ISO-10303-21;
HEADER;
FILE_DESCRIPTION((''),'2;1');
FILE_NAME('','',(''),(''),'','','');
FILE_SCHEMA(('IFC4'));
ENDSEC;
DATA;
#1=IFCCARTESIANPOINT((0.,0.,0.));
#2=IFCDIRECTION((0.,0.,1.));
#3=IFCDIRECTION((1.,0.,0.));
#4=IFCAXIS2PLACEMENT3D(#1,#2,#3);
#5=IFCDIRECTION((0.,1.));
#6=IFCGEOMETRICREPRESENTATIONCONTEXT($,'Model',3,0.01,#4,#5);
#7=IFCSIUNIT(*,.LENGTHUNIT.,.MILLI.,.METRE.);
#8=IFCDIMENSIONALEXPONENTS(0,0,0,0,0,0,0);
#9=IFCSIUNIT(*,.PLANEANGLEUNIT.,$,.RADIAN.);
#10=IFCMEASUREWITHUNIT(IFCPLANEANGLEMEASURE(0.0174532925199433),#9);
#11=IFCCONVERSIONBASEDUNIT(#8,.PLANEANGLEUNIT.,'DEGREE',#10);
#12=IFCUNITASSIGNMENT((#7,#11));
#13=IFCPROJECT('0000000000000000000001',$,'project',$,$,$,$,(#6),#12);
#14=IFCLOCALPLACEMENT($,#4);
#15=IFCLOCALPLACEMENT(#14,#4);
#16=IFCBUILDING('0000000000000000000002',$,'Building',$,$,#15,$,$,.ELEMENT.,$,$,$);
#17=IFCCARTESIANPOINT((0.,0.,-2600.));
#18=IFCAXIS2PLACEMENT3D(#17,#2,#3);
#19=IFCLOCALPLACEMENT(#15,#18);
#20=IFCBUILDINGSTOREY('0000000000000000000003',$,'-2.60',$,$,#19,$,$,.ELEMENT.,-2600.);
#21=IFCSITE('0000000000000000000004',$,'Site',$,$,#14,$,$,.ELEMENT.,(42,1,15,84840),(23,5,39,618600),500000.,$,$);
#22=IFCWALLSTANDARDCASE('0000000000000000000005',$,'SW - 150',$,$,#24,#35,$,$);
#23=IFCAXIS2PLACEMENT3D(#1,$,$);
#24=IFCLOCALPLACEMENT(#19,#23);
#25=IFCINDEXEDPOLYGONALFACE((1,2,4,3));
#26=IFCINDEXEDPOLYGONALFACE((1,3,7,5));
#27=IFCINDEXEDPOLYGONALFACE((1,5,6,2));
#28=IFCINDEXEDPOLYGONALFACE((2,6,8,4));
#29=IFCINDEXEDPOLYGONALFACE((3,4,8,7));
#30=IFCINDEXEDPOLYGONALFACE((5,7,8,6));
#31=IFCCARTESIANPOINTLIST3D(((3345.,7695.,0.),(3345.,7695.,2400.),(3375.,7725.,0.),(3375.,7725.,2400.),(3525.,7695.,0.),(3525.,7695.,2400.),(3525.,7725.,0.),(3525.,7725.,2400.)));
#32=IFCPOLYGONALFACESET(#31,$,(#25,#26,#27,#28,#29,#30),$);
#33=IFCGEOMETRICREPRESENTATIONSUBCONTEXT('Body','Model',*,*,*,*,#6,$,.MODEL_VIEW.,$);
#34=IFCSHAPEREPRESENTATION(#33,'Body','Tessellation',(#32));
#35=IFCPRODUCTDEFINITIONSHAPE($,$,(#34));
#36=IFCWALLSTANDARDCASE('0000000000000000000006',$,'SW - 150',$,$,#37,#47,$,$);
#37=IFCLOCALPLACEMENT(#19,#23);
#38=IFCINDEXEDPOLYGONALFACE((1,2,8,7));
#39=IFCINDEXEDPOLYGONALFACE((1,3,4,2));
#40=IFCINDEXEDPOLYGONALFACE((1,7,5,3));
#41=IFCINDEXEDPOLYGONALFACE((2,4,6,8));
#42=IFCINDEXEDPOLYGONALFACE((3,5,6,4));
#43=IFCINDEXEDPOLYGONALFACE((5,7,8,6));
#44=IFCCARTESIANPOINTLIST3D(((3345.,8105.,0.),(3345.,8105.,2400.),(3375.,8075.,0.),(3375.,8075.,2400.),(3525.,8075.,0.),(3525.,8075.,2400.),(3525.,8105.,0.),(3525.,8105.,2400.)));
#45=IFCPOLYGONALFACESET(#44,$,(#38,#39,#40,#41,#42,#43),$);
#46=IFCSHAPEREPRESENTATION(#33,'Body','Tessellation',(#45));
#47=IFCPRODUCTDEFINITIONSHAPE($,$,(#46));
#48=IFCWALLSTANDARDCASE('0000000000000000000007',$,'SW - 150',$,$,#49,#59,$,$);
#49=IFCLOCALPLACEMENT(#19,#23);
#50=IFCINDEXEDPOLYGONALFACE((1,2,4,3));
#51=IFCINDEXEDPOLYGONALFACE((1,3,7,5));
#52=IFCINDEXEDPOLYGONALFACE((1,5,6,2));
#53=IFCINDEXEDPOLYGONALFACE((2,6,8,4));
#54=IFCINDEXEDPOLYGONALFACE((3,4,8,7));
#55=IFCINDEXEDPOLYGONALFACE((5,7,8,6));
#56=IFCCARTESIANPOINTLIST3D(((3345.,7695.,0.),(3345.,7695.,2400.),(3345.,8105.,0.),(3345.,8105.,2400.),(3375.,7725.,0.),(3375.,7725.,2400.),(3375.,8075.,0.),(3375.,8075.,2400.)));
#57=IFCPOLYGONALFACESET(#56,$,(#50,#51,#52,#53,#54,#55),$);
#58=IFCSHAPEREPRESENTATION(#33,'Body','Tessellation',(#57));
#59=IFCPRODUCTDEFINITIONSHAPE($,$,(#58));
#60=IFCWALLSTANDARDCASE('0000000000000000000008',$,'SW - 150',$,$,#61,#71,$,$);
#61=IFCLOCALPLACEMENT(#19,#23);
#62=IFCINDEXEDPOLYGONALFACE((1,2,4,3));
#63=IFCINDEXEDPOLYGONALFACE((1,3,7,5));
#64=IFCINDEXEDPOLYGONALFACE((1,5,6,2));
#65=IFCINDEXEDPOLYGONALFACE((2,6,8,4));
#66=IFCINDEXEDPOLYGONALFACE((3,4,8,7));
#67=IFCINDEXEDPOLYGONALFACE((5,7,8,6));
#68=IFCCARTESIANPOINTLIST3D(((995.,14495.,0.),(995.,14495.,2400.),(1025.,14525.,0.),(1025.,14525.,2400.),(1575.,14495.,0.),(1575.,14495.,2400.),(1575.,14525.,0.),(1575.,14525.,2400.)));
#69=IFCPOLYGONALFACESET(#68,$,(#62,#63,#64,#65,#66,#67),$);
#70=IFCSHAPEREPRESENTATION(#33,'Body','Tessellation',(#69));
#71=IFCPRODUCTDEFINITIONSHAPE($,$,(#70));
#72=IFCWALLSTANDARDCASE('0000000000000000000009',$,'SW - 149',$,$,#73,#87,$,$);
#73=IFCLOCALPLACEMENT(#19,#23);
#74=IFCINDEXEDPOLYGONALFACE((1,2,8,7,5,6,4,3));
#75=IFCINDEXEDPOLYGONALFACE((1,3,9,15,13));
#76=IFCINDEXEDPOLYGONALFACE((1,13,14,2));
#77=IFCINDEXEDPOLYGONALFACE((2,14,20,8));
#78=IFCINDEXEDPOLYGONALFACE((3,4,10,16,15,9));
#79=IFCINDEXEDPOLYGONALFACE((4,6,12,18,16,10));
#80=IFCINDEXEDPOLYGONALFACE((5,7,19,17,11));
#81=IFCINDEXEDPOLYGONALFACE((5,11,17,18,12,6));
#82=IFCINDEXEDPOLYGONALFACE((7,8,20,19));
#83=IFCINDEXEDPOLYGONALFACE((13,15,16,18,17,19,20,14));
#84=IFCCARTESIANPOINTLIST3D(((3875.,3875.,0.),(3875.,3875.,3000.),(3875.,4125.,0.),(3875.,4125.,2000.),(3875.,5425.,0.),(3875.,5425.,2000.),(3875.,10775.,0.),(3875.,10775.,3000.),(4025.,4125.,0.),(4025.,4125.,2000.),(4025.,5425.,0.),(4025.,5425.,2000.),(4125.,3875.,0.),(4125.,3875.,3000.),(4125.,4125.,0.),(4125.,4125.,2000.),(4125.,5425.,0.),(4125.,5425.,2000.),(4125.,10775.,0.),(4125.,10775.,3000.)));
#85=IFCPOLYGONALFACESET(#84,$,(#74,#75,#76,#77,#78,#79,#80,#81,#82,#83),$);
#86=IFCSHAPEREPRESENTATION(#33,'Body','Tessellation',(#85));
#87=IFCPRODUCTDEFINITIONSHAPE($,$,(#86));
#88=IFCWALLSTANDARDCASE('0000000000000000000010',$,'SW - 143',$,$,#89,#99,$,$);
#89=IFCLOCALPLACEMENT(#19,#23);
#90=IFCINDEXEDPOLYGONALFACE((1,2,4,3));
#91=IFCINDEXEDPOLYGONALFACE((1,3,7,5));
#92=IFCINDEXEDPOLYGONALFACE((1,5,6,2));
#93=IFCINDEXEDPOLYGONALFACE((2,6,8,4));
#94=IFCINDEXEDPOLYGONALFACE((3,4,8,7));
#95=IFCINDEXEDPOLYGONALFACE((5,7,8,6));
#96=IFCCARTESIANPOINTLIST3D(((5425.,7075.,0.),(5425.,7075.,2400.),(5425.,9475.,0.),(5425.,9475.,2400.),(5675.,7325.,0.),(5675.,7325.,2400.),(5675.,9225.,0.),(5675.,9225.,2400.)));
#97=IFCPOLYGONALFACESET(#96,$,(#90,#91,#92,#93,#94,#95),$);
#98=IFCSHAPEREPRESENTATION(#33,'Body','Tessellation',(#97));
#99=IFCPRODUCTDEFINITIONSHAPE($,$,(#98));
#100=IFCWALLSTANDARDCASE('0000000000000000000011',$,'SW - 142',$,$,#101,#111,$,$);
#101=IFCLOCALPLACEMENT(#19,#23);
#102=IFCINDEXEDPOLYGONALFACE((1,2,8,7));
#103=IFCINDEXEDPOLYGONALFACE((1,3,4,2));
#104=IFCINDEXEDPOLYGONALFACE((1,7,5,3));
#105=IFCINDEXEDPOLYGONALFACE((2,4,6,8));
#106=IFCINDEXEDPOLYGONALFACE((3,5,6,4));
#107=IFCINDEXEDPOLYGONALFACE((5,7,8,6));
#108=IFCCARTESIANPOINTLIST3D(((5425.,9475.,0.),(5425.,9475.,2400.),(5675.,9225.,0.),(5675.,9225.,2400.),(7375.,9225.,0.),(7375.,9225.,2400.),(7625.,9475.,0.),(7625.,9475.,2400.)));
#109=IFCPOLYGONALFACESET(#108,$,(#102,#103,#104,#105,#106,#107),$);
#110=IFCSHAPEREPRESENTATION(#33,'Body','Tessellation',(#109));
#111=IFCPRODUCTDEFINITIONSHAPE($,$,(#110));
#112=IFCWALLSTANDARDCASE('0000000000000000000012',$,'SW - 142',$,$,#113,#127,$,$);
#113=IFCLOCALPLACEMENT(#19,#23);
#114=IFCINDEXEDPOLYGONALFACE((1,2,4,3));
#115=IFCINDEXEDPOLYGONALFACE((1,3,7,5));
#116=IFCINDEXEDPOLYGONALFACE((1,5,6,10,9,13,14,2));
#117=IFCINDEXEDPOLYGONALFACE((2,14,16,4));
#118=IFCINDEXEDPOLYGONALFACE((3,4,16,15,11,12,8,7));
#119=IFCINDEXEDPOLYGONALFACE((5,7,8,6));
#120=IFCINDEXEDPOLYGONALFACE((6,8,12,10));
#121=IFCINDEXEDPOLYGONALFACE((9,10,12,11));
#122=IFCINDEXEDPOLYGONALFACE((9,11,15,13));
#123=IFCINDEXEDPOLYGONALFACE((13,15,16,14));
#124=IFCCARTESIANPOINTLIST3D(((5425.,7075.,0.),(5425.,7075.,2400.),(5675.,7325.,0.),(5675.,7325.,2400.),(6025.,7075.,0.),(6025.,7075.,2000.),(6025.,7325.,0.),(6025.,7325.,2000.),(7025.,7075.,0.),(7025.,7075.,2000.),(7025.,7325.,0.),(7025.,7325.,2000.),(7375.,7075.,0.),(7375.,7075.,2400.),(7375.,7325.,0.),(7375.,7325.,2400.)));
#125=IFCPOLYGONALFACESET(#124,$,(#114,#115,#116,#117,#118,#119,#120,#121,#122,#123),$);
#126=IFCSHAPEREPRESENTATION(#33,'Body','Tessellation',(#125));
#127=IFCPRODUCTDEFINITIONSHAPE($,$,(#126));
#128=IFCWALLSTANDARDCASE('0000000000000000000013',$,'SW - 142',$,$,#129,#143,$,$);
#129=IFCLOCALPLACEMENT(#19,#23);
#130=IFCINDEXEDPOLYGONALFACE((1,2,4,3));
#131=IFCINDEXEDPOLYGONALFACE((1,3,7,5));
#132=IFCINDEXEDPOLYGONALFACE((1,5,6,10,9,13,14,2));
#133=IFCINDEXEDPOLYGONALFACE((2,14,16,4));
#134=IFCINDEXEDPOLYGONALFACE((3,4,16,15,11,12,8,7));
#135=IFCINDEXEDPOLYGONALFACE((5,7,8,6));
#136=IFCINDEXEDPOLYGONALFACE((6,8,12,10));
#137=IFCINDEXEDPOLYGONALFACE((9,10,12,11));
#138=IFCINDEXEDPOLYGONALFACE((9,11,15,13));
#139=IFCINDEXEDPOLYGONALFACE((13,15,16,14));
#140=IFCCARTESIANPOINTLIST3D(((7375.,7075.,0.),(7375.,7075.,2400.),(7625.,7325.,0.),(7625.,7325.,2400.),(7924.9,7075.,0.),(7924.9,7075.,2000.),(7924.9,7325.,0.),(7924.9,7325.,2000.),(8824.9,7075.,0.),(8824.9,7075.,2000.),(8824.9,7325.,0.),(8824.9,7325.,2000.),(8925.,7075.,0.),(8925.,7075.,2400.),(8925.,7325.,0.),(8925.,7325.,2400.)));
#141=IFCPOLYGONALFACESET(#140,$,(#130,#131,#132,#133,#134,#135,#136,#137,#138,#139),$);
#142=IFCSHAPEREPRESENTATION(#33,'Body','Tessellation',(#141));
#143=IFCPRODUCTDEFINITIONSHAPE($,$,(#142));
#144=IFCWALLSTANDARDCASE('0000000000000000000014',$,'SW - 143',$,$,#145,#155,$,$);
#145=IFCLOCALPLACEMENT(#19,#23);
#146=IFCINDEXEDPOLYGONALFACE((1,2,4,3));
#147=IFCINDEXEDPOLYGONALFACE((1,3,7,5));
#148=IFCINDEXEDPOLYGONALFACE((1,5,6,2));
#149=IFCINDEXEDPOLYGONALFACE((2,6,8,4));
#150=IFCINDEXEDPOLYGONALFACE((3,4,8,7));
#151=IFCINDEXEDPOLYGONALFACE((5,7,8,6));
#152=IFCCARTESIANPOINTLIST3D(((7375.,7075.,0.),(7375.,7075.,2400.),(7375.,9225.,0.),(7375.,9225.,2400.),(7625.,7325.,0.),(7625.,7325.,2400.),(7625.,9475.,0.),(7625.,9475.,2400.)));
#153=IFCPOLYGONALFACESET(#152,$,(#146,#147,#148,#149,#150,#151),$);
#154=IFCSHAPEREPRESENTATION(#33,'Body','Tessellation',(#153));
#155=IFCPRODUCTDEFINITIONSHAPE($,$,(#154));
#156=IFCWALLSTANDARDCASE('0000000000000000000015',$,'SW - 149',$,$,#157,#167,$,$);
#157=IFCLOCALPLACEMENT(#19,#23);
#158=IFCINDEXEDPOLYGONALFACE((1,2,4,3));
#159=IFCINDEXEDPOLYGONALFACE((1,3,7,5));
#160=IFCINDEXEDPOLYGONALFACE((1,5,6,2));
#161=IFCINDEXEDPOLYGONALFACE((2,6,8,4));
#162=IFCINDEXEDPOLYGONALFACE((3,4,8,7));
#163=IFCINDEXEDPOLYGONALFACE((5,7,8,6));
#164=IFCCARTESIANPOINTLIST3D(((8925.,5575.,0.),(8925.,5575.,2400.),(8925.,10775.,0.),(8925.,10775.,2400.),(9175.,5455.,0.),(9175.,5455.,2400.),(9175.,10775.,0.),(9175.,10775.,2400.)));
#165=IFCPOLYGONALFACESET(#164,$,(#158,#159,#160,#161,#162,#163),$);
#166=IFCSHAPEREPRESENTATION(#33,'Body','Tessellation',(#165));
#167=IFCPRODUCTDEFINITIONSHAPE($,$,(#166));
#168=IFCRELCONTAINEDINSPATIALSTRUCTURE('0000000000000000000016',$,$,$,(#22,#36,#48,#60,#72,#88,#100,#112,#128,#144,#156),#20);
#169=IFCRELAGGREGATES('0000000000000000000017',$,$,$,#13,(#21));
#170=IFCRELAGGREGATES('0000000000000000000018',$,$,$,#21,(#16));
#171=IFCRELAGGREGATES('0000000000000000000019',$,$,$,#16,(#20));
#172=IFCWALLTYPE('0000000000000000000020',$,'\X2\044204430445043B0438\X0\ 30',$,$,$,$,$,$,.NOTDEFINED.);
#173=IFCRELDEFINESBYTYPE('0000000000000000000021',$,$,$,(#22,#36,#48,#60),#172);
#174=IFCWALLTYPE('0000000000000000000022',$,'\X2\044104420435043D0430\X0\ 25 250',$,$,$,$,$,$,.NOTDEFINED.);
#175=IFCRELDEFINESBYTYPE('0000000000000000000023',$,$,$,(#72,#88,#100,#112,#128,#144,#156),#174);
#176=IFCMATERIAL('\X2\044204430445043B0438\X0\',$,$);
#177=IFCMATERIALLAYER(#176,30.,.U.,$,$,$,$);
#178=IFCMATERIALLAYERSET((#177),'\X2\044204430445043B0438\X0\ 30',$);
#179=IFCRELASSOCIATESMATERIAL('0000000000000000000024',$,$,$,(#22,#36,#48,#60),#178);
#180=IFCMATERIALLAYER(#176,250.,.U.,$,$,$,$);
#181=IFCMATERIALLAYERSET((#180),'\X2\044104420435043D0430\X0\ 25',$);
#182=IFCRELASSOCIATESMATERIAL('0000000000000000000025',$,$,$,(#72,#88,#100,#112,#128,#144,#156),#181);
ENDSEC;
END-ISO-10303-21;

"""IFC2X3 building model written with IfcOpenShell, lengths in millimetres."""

from ifc_helpers import new_model, entity, si_unit, converted_unit, direction, frame, origin_with_axes, origin_2d_with_axis, place, context, subcontext, project, spatial, polyline, rectangle, outline, extrude, material, layer, layer_set, layer_usage, type_object, element, save


model = new_model("IFC2X3")

# Units and contexts
model_context = context("Model", 3, precision=0.01, world=origin_with_axes(), true_north=direction((0.0, 1.0)))
body_context = subcontext(model_context, "Body", "Model", "MODEL_VIEW")
ifc_project = project(units=[si_unit("LENGTHUNIT", "METRE", prefix="MILLI"), converted_unit("PLANEANGLEUNIT", "DEGREE", entity("IfcPlaneAngleMeasure", 0.0174532925199433), si_unit("PLANEANGLEUNIT", "RADIAN"), dimensions=[0, 0, 0, 0, 0, 0, 0])], contexts=[model_context])

# Site, building, storey
site_placement = place(None, origin_with_axes())
site = spatial("IfcSite", under=ifc_project, at=site_placement, Name="Site", CompositionType="ELEMENT", RefLatitude=(42, 1, 15, 84840), RefLongitude=(23, 5, 39, 618600), RefElevation=500000.0)
building_placement = place(site_placement, origin_with_axes())
building = spatial("IfcBuilding", under=site, at=building_placement, Name="Building", CompositionType="ELEMENT")
storey_placement = place(building_placement, frame((0.0, 0.0, -2600.0), z_axis=(0.0, 0.0, 1.0), x_axis=(1.0, 0.0, 0.0)))
storey = spatial("IfcBuildingStorey", under=building, at=storey_placement, Name="-2.60", CompositionType="ELEMENT", Elevation=-2600.0)

# Shared definitions
ifc_material_1 = material(Name="тухли")

# Walls
ifc_layer_1 = layer(ifc_material_1, 30.0, ventilated="UNKNOWN")
ifc_layer_set_1 = layer_set([ifc_layer_1], Name="тухли 30")
ifc_layer_usage_1 = layer_usage(ifc_layer_set_1, "AXIS2", "NEGATIVE", 0.0)
wall_type_1 = type_object("IfcWallType", Name="тухли 30", PredefinedType="NOTDEFINED")
wall_1_placement = place(storey_placement, frame((3525.0, 7695.0, 0.0), z_axis=(0.0, 0.0, 1.0), x_axis=(-1.0, 0.0, 0.0)))
element("IfcWallStandardCase", 1, at=wall_1_placement, inside=storey, type_object=wall_type_1, material=ifc_layer_usage_1, Name="SW - 150", context=body_context, shape_type="SweptSolid", body=[
    extrude(outline(polyline([(0.0, -30.0), (150.0, -30.0), (180.0, 0.0), (0.0, 0.0), (0.0, -30.0)])), origin_with_axes(), (0.0, 0.0, 1.0), 2400.0),
])
ifc_layer_usage_2 = layer_usage(ifc_layer_set_1, "AXIS2", "POSITIVE", 0.0)
wall_2_placement = place(storey_placement, frame((3525.0, 8105.0, 0.0), z_axis=(0.0, 0.0, 1.0), x_axis=(-1.0, 0.0, 0.0)))
element("IfcWallStandardCase", 2, at=wall_2_placement, inside=storey, type_object=wall_type_1, material=ifc_layer_usage_2, Name="SW - 150", context=body_context, shape_type="SweptSolid", body=[
    extrude(outline(polyline([(0.0, 0.0), (180.0, 0.0), (150.0, 30.0), (0.0, 30.0), (0.0, 0.0)])), origin_with_axes(), (0.0, 0.0, 1.0), 2400.0),
])
ifc_layer_usage_3 = layer_usage(ifc_layer_set_1, "AXIS2", "NEGATIVE", 0.0)
wall_3_placement = place(storey_placement, frame((3345.0, 7695.0, 0.0), z_axis=(0.0, 0.0, 1.0), x_axis=(0.0, 1.0, 0.0)))
element("IfcWallStandardCase", 3, at=wall_3_placement, inside=storey, type_object=wall_type_1, material=ifc_layer_usage_3, Name="SW - 150", context=body_context, shape_type="SweptSolid", body=[
    extrude(outline(polyline([(30.0, -30.0), (380.0, -30.0), (410.0, 0.0), (0.0, 0.0), (30.0, -30.0)])), origin_with_axes(), (0.0, 0.0, 1.0), 2400.0),
])
ifc_layer_usage_4 = layer_usage(ifc_layer_set_1, "AXIS2", "POSITIVE", 0.0)
wall_4_placement = place(storey_placement, frame((995.0, 14495.0, 0.0), z_axis=(0.0, 0.0, 1.0), x_axis=(1.0, 0.0, 0.0)))
element("IfcWallStandardCase", 4, at=wall_4_placement, inside=storey, type_object=wall_type_1, material=ifc_layer_usage_4, Name="SW - 150", context=body_context, shape_type="SweptSolid", body=[
    extrude(outline(polyline([(0.0, 0.0), (580.0, 0.0), (580.0, 30.0), (30.0, 30.0), (0.0, 0.0)])), origin_with_axes(), (0.0, 0.0, 1.0), 2400.0),
])

# Wall, opening
ifc_layer_2 = layer(ifc_material_1, 250.0, ventilated="UNKNOWN")
ifc_layer_set_2 = layer_set([ifc_layer_2], Name="стена 25")
ifc_layer_usage_5 = layer_usage(ifc_layer_set_2, "AXIS2", "NEGATIVE", 0.0)
wall_type_2 = type_object("IfcWallType", Name="стена 25 250", PredefinedType="NOTDEFINED")
wall_5_placement = place(storey_placement, frame((3875.0, 3875.0, 0.0), z_axis=(0.0, 0.0, 1.0), x_axis=(0.0, 1.0, 0.0)))
wall_5 = element("IfcWallStandardCase", 5, at=wall_5_placement, inside=storey, type_object=wall_type_2, material=ifc_layer_usage_5, Name="SW - 149", context=body_context, shape_type="SweptSolid", body=[
    extrude(outline(polyline([(0.0, -250.0), (6900.0, -250.0), (6900.0, 0.0), (0.0, 0.0), (0.0, -250.0)])), origin_with_axes(), (0.0, 0.0, 1.0), 3000.0),
])
opening_1_placement = place(wall_5_placement, frame((900.0, 0.0, 0.0), z_axis=(0.0, 0.0, 1.0), x_axis=(1.0, 0.0, 0.0)))
element("IfcOpeningElement", 6, at=opening_1_placement, cuts=wall_5, context=body_context, shape_type="SweptSolid", body=[
    extrude(rectangle(XDim=1300.0, YDim=2000.0, at=origin_2d_with_axis()), frame((0.0, -150.0, 1000.0), z_axis=(0.0, -1.0, 0.0), x_axis=(-1.0, 0.0, 0.0)), (0.0, 0.0, -1.0), 400.0),
    extrude(rectangle(XDim=1300.0, YDim=2000.0, at=origin_2d_with_axis()), frame((0.0, -150.0, 1000.0), z_axis=(0.0, 1.0, 0.0), x_axis=(-1.0, 0.0, 0.0)), (0.0, 0.0, -1.0), 350.0),
])

# Walls
ifc_layer_usage_6 = layer_usage(ifc_layer_set_2, "AXIS2", "POSITIVE", 0.0)
wall_6_placement = place(storey_placement, frame((5425.0, 9475.0, 0.0), z_axis=(0.0, 0.0, 1.0), x_axis=(0.0, -1.0, 0.0)))
element("IfcWallStandardCase", 7, at=wall_6_placement, inside=storey, type_object=wall_type_2, material=ifc_layer_usage_6, Name="SW - 143", context=body_context, shape_type="SweptSolid", body=[
    extrude(outline(polyline([(0.0, 0.0), (2400.0, 0.0), (2150.0, 250.0), (250.0, 250.0), (0.0, 0.0)])), origin_with_axes(), (0.0, 0.0, 1.0), 2400.0),
])
ifc_layer_usage_7 = layer_usage(ifc_layer_set_2, "AXIS2", "POSITIVE", 0.0)
wall_7_placement = place(storey_placement, frame((7625.0, 9475.0, 0.0), z_axis=(0.0, 0.0, 1.0), x_axis=(-1.0, 0.0, 0.0)))
element("IfcWallStandardCase", 8, at=wall_7_placement, inside=storey, type_object=wall_type_2, material=ifc_layer_usage_7, Name="SW - 142", context=body_context, shape_type="SweptSolid", body=[
    extrude(outline(polyline([(0.0, 0.0), (2200.0, 0.0), (1950.0, 250.0), (250.0, 250.0), (0.0, 0.0)])), origin_with_axes(), (0.0, 0.0, 1.0), 2400.0),
])

# Walls, openings
ifc_layer_usage_8 = layer_usage(ifc_layer_set_2, "AXIS2", "NEGATIVE", 0.0)
wall_8_placement = place(storey_placement, frame((7625.0, 7075.0, 0.0), z_axis=(0.0, 0.0, 1.0), x_axis=(-1.0, 0.0, 0.0)))
wall_8 = element("IfcWallStandardCase", 9, at=wall_8_placement, inside=storey, type_object=wall_type_2, material=ifc_layer_usage_8, Name="SW - 142", context=body_context, shape_type="SweptSolid", body=[
    extrude(outline(polyline([(250.0, -250.0), (1950.0, -250.0), (2200.0, 0.0), (250.0, 0.0), (250.0, -250.0)])), origin_with_axes(), (0.0, 0.0, 1.0), 2400.0),
])
opening_2_placement = place(wall_8_placement, frame((1100.0, 0.0, 0.0), z_axis=(0.0, 0.0, 1.0), x_axis=(1.0, 0.0, 0.0)))
element("IfcOpeningElement", 10, at=opening_2_placement, cuts=wall_8, context=body_context, shape_type="SweptSolid", body=[
    extrude(rectangle(XDim=1000.0, YDim=2000.0, at=origin_2d_with_axis()), frame((0.0, -250.0, 1000.0), z_axis=(0.0, 1.0, 0.0), x_axis=(-1.0, 0.0, 0.0)), (0.0, 0.0, 1.0), 750.0),
])
ifc_layer_usage_9 = layer_usage(ifc_layer_set_2, "AXIS2", "NEGATIVE", 0.0)
wall_9_placement = place(storey_placement, frame((8925.0, 7075.0, 0.0), z_axis=(0.0, 0.0, 1.0), x_axis=(-1.0, 0.0, 0.0)))
wall_9 = element("IfcWallStandardCase", 11, at=wall_9_placement, inside=storey, type_object=wall_type_2, material=ifc_layer_usage_9, Name="SW - 142", context=body_context, shape_type="SweptSolid", body=[
    extrude(outline(polyline([(0.0, -250.0), (1300.0, -250.0), (1550.0, 0.0), (0.0, 0.0), (0.0, -250.0)])), origin_with_axes(), (0.0, 0.0, 1.0), 2400.0),
])
opening_3_placement = place(wall_9_placement, frame((550.1, 0.0, 0.0), z_axis=(0.0, 0.0, 1.0), x_axis=(1.0, 0.0, 0.0)))
element("IfcOpeningElement", 12, at=opening_3_placement, cuts=wall_9, context=body_context, shape_type="SweptSolid", body=[
    extrude(rectangle(XDim=900.0, YDim=2000.0, at=origin_2d_with_axis()), frame((0.0, 250.0, 1000.0), z_axis=(0.0, -1.0, 0.0), x_axis=(-1.0, 0.0, 0.0)), (0.0, 0.0, 1.0), 750.0),
])

# Walls
ifc_layer_usage_10 = layer_usage(ifc_layer_set_2, "AXIS2", "NEGATIVE", 0.0)
wall_10_placement = place(storey_placement, frame((7625.0, 9475.0, 0.0), z_axis=(0.0, 0.0, 1.0), x_axis=(0.0, -1.0, 0.0)))
element("IfcWallStandardCase", 13, at=wall_10_placement, inside=storey, type_object=wall_type_2, material=ifc_layer_usage_10, Name="SW - 143", context=body_context, shape_type="SweptSolid", body=[
    extrude(outline(polyline([(250.0, -250.0), (2400.0, -250.0), (2150.0, 0.0), (0.0, 0.0), (250.0, -250.0)])), origin_with_axes(), (0.0, 0.0, 1.0), 2400.0),
])
ifc_layer_usage_11 = layer_usage(ifc_layer_set_2, "AXIS2", "NEGATIVE", 0.0)
wall_11_placement = place(storey_placement, frame((8925.0, 5575.0, 0.0), z_axis=(0.0, 0.0, 1.0), x_axis=(0.0, 1.0, 0.0)))
element("IfcWallStandardCase", 14, at=wall_11_placement, inside=storey, type_object=wall_type_2, material=ifc_layer_usage_11, Name="SW - 149", context=body_context, shape_type="SweptSolid", body=[
    extrude(outline(polyline([(-120.0, -250.0), (5200.0, -250.0), (5200.0, 0.0), (0.0, 0.0), (-120.0, -250.0)])), origin_with_axes(), (0.0, 0.0, 1.0), 2400.0),
])

save(model, "model.ifc")
